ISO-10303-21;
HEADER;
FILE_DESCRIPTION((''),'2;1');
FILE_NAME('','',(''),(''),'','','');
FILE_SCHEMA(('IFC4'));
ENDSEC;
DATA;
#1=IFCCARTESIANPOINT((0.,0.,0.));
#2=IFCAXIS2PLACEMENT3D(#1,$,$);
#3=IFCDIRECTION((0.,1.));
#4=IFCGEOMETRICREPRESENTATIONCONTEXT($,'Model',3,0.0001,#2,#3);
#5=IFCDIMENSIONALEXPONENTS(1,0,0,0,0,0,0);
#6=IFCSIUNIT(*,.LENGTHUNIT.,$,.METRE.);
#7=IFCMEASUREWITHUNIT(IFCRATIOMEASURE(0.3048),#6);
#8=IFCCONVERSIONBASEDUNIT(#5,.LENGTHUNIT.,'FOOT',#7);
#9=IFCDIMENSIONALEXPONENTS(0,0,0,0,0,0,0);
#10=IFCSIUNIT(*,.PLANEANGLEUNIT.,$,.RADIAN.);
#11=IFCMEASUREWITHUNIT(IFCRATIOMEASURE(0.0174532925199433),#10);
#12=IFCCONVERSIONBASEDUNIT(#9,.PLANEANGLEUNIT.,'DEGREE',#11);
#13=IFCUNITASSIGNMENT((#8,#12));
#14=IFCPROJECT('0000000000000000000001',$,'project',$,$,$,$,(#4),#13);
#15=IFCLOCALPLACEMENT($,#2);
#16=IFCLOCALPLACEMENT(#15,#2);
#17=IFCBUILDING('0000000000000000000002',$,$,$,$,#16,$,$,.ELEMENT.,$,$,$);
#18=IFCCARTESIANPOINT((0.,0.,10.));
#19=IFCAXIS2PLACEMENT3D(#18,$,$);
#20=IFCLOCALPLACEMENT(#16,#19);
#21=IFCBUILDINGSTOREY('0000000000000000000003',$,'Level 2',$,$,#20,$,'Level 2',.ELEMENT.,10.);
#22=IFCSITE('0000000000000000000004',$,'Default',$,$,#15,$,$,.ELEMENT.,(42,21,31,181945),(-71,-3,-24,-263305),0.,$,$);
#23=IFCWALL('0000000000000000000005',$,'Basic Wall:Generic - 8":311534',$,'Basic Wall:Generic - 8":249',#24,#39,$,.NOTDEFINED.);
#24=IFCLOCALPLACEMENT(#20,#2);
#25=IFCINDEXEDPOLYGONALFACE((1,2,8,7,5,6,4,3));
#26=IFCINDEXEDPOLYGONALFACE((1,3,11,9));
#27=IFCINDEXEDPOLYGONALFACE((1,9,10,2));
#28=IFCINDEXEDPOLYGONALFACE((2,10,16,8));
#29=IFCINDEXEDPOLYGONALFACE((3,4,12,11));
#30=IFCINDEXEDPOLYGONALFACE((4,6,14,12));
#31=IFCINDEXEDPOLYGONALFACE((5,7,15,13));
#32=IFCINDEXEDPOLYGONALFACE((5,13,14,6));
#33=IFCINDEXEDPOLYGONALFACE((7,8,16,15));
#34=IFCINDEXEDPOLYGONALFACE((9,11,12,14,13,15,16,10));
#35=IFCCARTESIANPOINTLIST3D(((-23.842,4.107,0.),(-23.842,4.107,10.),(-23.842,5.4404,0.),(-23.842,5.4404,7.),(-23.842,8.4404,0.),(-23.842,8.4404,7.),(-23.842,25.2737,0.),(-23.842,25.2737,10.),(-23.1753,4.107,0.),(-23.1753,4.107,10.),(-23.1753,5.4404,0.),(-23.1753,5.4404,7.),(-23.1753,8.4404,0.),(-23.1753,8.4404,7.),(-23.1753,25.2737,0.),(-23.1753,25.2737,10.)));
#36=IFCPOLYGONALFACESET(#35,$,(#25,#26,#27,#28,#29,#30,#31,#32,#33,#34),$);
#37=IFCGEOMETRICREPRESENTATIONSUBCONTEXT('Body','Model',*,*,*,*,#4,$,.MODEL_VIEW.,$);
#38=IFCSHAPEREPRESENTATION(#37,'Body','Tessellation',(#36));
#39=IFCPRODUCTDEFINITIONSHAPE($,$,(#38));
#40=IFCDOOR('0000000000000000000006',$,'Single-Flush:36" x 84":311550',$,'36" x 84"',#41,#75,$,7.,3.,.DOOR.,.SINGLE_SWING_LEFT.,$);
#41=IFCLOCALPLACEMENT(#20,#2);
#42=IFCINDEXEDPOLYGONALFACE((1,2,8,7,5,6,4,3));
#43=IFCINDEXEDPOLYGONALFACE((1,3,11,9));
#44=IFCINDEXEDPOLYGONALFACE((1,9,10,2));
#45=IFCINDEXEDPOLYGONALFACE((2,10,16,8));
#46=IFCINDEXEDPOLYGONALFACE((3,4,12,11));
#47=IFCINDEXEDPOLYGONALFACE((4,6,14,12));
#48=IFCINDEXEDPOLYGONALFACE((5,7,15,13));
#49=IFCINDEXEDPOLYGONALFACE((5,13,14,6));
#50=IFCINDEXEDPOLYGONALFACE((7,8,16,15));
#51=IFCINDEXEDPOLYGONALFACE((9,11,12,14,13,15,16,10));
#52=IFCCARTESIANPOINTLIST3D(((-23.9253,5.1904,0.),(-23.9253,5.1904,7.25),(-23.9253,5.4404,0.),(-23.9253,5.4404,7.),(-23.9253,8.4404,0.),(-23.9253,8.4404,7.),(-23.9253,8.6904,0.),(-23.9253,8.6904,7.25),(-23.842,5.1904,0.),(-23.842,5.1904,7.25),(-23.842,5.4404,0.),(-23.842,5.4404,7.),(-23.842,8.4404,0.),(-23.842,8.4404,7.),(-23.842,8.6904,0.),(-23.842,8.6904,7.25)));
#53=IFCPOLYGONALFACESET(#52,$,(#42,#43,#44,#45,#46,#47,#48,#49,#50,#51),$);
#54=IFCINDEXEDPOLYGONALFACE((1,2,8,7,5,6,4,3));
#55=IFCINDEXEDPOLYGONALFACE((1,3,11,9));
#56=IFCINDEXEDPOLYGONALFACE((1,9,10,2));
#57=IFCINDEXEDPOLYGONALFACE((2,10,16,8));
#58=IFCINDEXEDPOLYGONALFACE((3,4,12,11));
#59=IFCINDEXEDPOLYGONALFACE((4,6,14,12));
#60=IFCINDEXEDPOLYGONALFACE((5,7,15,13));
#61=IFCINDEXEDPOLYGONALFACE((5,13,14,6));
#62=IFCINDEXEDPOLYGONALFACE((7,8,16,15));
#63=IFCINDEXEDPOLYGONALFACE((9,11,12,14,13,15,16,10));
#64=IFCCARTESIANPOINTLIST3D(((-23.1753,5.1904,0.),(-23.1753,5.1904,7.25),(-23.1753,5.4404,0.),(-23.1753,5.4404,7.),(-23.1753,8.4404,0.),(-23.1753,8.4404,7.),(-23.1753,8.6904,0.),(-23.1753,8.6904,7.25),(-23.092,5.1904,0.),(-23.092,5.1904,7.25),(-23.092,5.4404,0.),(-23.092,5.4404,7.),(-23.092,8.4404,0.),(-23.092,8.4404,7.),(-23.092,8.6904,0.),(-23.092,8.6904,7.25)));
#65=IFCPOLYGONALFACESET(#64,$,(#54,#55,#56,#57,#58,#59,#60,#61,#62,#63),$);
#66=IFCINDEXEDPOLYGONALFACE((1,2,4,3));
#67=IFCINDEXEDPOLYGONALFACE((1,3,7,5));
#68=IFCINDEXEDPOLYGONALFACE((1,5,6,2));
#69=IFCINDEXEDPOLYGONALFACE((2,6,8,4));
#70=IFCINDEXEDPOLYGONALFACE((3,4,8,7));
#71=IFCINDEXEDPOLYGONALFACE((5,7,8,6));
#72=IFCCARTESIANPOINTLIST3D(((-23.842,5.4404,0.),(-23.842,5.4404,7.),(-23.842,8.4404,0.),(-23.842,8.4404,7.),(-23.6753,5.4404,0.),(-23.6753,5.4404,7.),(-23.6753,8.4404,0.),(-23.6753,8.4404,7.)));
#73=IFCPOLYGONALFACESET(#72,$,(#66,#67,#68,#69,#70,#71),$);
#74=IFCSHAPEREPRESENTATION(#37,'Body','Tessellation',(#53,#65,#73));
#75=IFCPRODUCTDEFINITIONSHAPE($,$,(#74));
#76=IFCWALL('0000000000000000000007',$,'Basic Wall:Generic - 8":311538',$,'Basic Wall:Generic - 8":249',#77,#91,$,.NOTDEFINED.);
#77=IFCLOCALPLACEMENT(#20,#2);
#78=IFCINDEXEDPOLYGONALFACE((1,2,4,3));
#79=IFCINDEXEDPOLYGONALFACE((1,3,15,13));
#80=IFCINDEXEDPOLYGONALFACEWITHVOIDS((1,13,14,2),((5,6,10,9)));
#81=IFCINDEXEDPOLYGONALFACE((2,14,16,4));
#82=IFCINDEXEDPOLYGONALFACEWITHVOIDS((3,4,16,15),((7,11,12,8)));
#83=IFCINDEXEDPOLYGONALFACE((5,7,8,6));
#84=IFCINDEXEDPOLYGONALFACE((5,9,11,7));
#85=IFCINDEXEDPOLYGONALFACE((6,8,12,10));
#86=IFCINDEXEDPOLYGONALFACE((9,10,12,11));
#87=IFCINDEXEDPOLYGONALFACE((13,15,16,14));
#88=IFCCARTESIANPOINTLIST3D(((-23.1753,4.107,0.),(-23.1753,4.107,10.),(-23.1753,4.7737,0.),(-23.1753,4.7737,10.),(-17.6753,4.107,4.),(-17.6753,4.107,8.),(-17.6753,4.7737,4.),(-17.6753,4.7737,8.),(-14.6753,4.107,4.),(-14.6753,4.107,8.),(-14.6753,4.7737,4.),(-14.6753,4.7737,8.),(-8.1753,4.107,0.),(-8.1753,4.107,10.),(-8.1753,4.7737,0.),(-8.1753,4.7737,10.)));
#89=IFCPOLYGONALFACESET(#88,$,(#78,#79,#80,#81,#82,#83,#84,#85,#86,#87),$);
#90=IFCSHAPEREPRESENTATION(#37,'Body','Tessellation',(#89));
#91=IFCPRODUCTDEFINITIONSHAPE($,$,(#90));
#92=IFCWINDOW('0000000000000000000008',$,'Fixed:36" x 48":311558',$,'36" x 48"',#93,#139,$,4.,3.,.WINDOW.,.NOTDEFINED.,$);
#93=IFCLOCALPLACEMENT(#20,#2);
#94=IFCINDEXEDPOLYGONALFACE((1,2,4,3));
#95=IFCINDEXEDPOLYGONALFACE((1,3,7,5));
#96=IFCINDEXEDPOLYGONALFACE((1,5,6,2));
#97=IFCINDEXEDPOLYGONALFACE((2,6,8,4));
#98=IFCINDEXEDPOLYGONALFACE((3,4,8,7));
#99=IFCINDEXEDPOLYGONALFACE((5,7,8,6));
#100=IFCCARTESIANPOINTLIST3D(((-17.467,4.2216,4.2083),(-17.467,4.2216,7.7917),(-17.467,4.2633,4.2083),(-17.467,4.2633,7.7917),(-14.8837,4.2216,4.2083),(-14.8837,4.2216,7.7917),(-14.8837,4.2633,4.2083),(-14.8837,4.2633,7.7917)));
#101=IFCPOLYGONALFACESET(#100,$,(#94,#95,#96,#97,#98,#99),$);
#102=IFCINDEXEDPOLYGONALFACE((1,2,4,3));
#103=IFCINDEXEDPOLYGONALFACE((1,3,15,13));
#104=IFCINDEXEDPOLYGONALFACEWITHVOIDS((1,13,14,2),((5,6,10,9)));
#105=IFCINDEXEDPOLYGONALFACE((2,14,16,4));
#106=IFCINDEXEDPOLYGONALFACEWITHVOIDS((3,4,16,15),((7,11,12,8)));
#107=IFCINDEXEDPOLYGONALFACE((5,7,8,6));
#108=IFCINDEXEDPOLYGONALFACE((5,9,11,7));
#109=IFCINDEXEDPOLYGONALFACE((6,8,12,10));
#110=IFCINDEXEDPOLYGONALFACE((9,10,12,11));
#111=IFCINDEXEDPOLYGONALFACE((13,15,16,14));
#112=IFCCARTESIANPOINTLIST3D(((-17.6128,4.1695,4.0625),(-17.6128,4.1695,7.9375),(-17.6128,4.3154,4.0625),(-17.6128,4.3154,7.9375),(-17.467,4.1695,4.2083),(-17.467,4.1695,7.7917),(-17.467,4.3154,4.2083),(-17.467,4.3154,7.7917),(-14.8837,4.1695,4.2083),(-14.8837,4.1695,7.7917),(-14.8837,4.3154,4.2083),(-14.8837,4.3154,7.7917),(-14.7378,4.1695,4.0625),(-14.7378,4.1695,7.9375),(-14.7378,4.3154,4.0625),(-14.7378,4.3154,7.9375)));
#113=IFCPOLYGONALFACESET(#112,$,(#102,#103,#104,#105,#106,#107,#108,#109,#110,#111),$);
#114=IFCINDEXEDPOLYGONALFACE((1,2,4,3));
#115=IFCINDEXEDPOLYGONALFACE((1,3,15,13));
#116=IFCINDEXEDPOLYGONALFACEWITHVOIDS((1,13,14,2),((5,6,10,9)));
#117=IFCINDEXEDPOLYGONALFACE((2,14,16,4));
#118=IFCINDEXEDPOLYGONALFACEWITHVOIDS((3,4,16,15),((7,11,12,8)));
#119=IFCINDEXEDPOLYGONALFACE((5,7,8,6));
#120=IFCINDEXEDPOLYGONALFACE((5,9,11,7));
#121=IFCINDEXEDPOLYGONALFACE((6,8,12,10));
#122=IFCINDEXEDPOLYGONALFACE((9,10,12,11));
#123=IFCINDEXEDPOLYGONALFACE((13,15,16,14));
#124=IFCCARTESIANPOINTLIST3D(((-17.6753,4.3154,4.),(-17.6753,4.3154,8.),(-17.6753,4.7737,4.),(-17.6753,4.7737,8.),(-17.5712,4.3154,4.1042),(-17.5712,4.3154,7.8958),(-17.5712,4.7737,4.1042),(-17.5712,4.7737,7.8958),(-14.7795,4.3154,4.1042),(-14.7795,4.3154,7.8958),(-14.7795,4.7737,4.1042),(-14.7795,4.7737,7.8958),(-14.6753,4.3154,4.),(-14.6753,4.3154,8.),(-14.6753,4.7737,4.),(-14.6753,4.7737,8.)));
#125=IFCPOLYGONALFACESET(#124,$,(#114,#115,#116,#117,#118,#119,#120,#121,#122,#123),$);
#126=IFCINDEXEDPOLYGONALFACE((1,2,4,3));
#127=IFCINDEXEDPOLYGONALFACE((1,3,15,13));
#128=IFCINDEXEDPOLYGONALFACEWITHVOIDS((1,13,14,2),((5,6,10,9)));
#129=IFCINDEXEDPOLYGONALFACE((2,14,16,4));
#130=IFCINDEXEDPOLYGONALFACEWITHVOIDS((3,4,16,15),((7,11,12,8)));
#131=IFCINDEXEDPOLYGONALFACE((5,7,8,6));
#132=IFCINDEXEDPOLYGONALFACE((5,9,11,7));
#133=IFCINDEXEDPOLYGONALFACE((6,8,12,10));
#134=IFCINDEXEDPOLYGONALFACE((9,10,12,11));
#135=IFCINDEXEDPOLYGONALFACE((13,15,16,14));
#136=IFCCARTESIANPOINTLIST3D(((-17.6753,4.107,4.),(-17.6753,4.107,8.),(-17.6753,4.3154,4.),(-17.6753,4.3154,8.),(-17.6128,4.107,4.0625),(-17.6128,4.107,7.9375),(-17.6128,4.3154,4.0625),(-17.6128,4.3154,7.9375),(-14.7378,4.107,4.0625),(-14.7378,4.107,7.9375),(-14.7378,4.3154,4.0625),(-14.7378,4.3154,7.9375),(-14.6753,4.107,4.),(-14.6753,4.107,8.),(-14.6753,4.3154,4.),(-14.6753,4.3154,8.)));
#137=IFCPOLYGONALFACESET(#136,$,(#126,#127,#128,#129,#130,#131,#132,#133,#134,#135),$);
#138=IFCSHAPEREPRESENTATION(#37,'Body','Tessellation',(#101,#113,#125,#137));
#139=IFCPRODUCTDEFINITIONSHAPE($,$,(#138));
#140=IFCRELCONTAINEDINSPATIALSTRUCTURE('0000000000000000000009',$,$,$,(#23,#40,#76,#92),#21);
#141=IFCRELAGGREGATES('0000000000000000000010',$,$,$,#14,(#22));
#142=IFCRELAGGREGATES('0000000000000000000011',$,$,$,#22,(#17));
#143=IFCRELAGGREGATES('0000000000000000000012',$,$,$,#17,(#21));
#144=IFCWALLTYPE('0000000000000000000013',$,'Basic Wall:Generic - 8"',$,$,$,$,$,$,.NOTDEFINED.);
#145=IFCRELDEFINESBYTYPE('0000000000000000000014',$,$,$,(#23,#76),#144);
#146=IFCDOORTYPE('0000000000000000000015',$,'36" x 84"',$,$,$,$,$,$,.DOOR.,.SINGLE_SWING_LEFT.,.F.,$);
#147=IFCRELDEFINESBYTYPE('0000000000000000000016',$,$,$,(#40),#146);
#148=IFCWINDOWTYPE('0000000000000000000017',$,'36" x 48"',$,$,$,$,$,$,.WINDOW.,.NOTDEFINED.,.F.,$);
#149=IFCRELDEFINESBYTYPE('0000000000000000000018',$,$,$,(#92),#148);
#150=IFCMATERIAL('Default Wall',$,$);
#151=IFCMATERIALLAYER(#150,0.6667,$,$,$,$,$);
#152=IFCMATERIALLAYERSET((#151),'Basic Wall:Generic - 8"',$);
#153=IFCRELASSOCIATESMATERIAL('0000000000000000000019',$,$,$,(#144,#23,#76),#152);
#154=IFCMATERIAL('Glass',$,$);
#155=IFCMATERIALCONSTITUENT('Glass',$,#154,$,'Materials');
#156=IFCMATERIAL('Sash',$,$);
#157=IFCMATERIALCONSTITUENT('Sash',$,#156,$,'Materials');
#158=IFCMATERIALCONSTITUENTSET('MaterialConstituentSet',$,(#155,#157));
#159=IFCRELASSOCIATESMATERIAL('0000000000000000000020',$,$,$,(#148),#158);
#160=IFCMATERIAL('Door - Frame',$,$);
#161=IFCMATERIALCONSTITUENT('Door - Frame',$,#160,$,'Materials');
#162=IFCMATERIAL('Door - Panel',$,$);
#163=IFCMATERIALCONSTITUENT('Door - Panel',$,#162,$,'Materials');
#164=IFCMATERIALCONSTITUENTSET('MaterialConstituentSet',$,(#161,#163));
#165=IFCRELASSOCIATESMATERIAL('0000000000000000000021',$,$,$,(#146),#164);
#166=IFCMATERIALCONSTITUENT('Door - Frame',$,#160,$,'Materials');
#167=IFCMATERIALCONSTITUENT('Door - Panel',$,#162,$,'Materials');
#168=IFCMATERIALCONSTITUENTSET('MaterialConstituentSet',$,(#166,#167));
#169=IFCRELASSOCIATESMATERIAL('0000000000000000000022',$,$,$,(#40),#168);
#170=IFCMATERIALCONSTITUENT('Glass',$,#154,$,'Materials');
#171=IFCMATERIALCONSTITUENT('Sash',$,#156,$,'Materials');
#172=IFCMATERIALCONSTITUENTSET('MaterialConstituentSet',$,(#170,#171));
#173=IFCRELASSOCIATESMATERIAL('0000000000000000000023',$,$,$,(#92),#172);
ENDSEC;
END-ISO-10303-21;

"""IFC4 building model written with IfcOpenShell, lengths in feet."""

from ifc_helpers import new_model, entity, si_unit, converted_unit, direction, frame, frame_2d, origin, place, context, subcontext, project, spatial, polyline, rectangle, outline, extrude, source, transform, mapped, material, layer, layer_set, layer_usage, constituent, constituent_set, type_object, type_shapes, element, fill, save


model = new_model("IFC4")

# Units and contexts
model_context = context("Model", 3, precision=0.0001, world=origin(), true_north=direction((0.0, 1.0)))
body_context = subcontext(model_context, "Body", "Model", "MODEL_VIEW")
ifc_project = project(units=[converted_unit("LENGTHUNIT", "FOOT", entity("IfcRatioMeasure", 0.3048), si_unit("LENGTHUNIT", "METRE"), dimensions=[1, 0, 0, 0, 0, 0, 0]), converted_unit("PLANEANGLEUNIT", "DEGREE", entity("IfcRatioMeasure", 0.0174532925199433), si_unit("PLANEANGLEUNIT", "RADIAN"), dimensions=[0, 0, 0, 0, 0, 0, 0])], contexts=[model_context])

# Site, building, storey
site_placement = place(None, origin())
site = spatial("IfcSite", under=ifc_project, at=site_placement, Name="Default", CompositionType="ELEMENT", RefLatitude=(42, 21, 31, 181945), RefLongitude=(-71, -3, -24, -263305), RefElevation=0.0)
building_placement = place(site_placement, origin())
building = spatial("IfcBuilding", under=site, at=building_placement, CompositionType="ELEMENT")
storey_placement = place(building_placement, frame((0.0, 0.0, 10.0)))
storey = spatial("IfcBuildingStorey", under=building, at=storey_placement, Name="Level 2", LongName="Level 2", CompositionType="ELEMENT", Elevation=10.0)

# Shared definitions
ifc_material_1 = material(Name="Default Wall")
ifc_layer_1 = layer(ifc_material_1, 0.6667)
ifc_layer_set_1 = layer_set([ifc_layer_1], Name="Basic Wall:Generic - 8\"")
wall_type = type_object("IfcWallType", Name="Basic Wall:Generic - 8\"", PredefinedType="NOTDEFINED", material=ifc_layer_set_1)
ifc_material_2 = material(Name="Glass")
ifc_material_3 = material(Name="Sash")
ifc_constituent_1 = constituent(ifc_material_2, Name="Glass", Category="Materials")
ifc_constituent_2 = constituent(ifc_material_3, Name="Sash", Category="Materials")
ifc_constituent_set_1 = constituent_set(constituents=[ifc_constituent_1, ifc_constituent_2], Name="MaterialConstituentSet")
window_type_1 = type_object("IfcWindowType", Name="36\" x 48\"", ParameterTakesPrecedence=False, PartitioningType="NOTDEFINED", PredefinedType="WINDOW", material=ifc_constituent_set_1)
shared_shape_1 = source(origin(), body_context, "Body", "SweptSolid", [
    extrude(rectangle(XDim=0.0417, YDim=2.5833, at=frame_2d((0.0, 0.0), x_axis=(1.0, 0.0))), frame((1.5, 0.5312, 0.2083), z_axis=(0.0, 0.0, 1.0), x_axis=(0.0, 1.0, 0.0)), (0.0, 0.0, 1.0), 3.5833),
    extrude(outline(polyline([(-1.4375, -1.9375), (1.4375, -1.9375), (1.4375, 1.9375), (-1.4375, 1.9375), (-1.4375, -1.9375)]), holes=[polyline([(-1.2917, -1.7917), (-1.2917, 1.7917), (1.2917, 1.7917), (1.2917, -1.7917), (-1.2917, -1.7917)])]), frame((1.5, 0.4583, 2.0), z_axis=(0.0, 1.0, 0.0), x_axis=(1.0, 0.0, 0.0)), (0.0, 0.0, 1.0), 0.1458),
    extrude(outline(polyline([(-1.5, -2.0), (1.5, -2.0), (1.5, 2.0), (-1.5, 2.0), (-1.5, -2.0)]), holes=[polyline([(-1.3958, -1.8958), (-1.3958, 1.8958), (1.3958, 1.8958), (1.3958, -1.8958), (-1.3958, -1.8958)])]), frame((1.5, 0.0, 2.0), z_axis=(0.0, 1.0, 0.0), x_axis=(1.0, 0.0, 0.0)), (0.0, 0.0, 1.0), 0.4583),
    extrude(outline(polyline([(-2.0, -1.5), (2.0, -1.5), (2.0, 1.5), (-2.0, 1.5), (-2.0, -1.5)]), holes=[polyline([(-1.9375, -1.4375), (-1.9375, 1.4375), (1.9375, 1.4375), (1.9375, -1.4375), (-1.9375, -1.4375)])]), frame((1.5, 0.4583, 2.0), z_axis=(0.0, 1.0, 0.0), x_axis=(0.0, 0.0, -1.0)), (0.0, 0.0, 1.0), 0.2083),
])
type_shapes(window_type_1, [shared_shape_1])

# Wall, opening, door
ifc_layer_usage_1 = layer_usage(ifc_layer_set_1, "AXIS2", "NEGATIVE", 0.3333)
wall_1_placement = place(storey_placement, frame((-23.5087, 25.2737, 0.0), z_axis=(0.0, 0.0, 1.0), x_axis=(0.0, -1.0, 0.0)))
wall_1 = element("IfcWall", 1, at=wall_1_placement, inside=storey, type_object=wall_type, material=ifc_layer_usage_1, Name="Basic Wall:Generic - 8\":311534", ObjectType="Basic Wall:Generic - 8\":249", PredefinedType="NOTDEFINED", context=body_context, shape_type="SweptSolid", body=[
    extrude(rectangle(XDim=21.1667, YDim=0.6667, at=frame_2d((10.5833, 0.0), x_axis=(-1.0, 0.0))), origin(), (0.0, 0.0, 1.0), 10.0),
])
opening_1_placement = place(wall_1_placement, frame((19.8333, 0.3333, 0.0)))
opening_1 = element("IfcOpeningElement", 2, at=opening_1_placement, cuts=wall_1, ObjectType="Opening", PredefinedType="OPENING", context=body_context, shape_type="SweptSolid", body=[
    extrude(rectangle(XDim=3.0, YDim=7.0, at=frame_2d((3.5, 1.5), x_axis=(0.0, -1.0))), frame((0.0, 0.0, 0.0), z_axis=(0.0, -1.0, 0.0), x_axis=(0.0, 0.0, 1.0)), (0.0, 0.0, 1.0), 0.6667),
])
ifc_material_4 = material(Name="Door - Frame")
ifc_constituent_3 = constituent(ifc_material_4, Name="Door - Frame", Category="Materials")
ifc_material_5 = material(Name="Door - Panel")
ifc_constituent_4 = constituent(ifc_material_5, Name="Door - Panel", Category="Materials")
ifc_constituent_set_2 = constituent_set(constituents=[ifc_constituent_3, ifc_constituent_4], Name="MaterialConstituentSet")
ifc_constituent_5 = constituent(ifc_material_4, Name="Door - Frame", Category="Materials")
ifc_constituent_6 = constituent(ifc_material_5, Name="Door - Panel", Category="Materials")
ifc_constituent_set_3 = constituent_set(constituents=[ifc_constituent_5, ifc_constituent_6], Name="MaterialConstituentSet")
door_type_1 = type_object("IfcDoorType", Name="36\" x 84\"", OperationType="SINGLE_SWING_LEFT", ParameterTakesPrecedence=False, PredefinedType="DOOR", material=ifc_constituent_set_3)
shared_shape_2 = source(origin(), body_context, "Body", "SweptSolid", [
    extrude(outline(polyline([(-1.75, -3.6875), (1.75, -3.6875), (1.75, 3.5625), (1.5, 3.5625), (1.5, -3.4375), (-1.5, -3.4375), (-1.5, 3.5625), (-1.75, 3.5625), (-1.75, -3.6875)])), frame((1.5, 0.75, 3.5625), z_axis=(0.0, -1.0, 0.0), x_axis=(-1.0, 0.0, 0.0)), (0.0, 0.0, 1.0), 0.0833),
    extrude(outline(polyline([(-3.6875, -1.75), (3.5625, -1.75), (3.5625, -1.5), (-3.4375, -1.5), (-3.4375, 1.5), (3.5625, 1.5), (3.5625, 1.75), (-3.6875, 1.75), (-3.6875, -1.75)])), frame((1.5, 0.0, 3.5625), z_axis=(0.0, -1.0, 0.0), x_axis=(0.0, 0.0, -1.0)), (0.0, 0.0, 1.0), 0.0833),
    extrude(rectangle(XDim=3.0, YDim=0.1667, at=frame_2d((0.0, 0.0), x_axis=(1.0, 0.0))), frame((1.5, 0.5833, 0.0)), (0.0, 0.0, 1.0), 7.0),
])
type_shapes(door_type_1, [shared_shape_2])
door_1_placement = place(opening_1_placement, frame((0.0, 0.0, 0.0), z_axis=(0.0, 0.0, 1.0), x_axis=(-1.0, 0.0, 0.0)))
door_1 = element("IfcDoor", 3, at=door_1_placement, inside=storey, type_object=door_type_1, material=ifc_constituent_set_2, Name="Single-Flush:36\" x 84\":311550", ObjectType="36\" x 84\"", OperationType="SINGLE_SWING_LEFT", OverallHeight=7.0, OverallWidth=3.0, PredefinedType="DOOR", context=body_context, shape_type="MappedRepresentation", body=[
    mapped(shared_shape_2, transform((0.0, 0.0, 0.0), scale=1.0)),
])
fill(opening_1, door_1)

# Wall, opening, window
ifc_layer_usage_2 = layer_usage(ifc_layer_set_1, "AXIS2", "NEGATIVE", 0.3333)
wall_2_placement = place(storey_placement, frame((-8.1753, 4.4404, 0.0), z_axis=(0.0, 0.0, 1.0), x_axis=(-1.0, 0.0, 0.0)))
wall_2 = element("IfcWall", 4, at=wall_2_placement, inside=storey, type_object=wall_type, material=ifc_layer_usage_2, Name="Basic Wall:Generic - 8\":311538", ObjectType="Basic Wall:Generic - 8\":249", PredefinedType="NOTDEFINED", context=body_context, shape_type="SweptSolid", body=[
    extrude(rectangle(XDim=15.0, YDim=0.6667, at=frame_2d((7.5, 0.0), x_axis=(-1.0, 0.0))), origin(), (0.0, 0.0, 1.0), 10.0),
])
opening_2_placement = place(wall_2_placement, frame((6.5, -0.3333, 4.0)))
opening_2 = element("IfcOpeningElement", 5, at=opening_2_placement, cuts=wall_2, ObjectType="Opening", PredefinedType="OPENING", context=body_context, shape_type="SweptSolid", body=[
    extrude(rectangle(XDim=4.0, YDim=3.0, at=frame_2d((2.0, 1.5), x_axis=(-1.0, 0.0))), frame((0.0, 0.0, 0.0), z_axis=(0.0, 1.0, 0.0), x_axis=(0.0, 0.0, 1.0)), (0.0, 0.0, 1.0), 0.6667),
])
ifc_constituent_7 = constituent(ifc_material_2, Name="Glass", Category="Materials")
ifc_constituent_8 = constituent(ifc_material_3, Name="Sash", Category="Materials")
ifc_constituent_set_4 = constituent_set(constituents=[ifc_constituent_7, ifc_constituent_8], Name="MaterialConstituentSet")
window_1_placement = place(opening_2_placement, origin())
window_1 = element("IfcWindow", 6, at=window_1_placement, inside=storey, type_object=window_type_1, material=ifc_constituent_set_4, Name="Fixed:36\" x 48\":311558", ObjectType="36\" x 48\"", OverallHeight=4.0, OverallWidth=3.0, PartitioningType="NOTDEFINED", PredefinedType="WINDOW", context=body_context, shape_type="MappedRepresentation", body=[
    mapped(shared_shape_1, transform((0.0, 0.0, 0.0), scale=1.0)),
])
fill(opening_2, window_1)

save(model, "model.ifc")
